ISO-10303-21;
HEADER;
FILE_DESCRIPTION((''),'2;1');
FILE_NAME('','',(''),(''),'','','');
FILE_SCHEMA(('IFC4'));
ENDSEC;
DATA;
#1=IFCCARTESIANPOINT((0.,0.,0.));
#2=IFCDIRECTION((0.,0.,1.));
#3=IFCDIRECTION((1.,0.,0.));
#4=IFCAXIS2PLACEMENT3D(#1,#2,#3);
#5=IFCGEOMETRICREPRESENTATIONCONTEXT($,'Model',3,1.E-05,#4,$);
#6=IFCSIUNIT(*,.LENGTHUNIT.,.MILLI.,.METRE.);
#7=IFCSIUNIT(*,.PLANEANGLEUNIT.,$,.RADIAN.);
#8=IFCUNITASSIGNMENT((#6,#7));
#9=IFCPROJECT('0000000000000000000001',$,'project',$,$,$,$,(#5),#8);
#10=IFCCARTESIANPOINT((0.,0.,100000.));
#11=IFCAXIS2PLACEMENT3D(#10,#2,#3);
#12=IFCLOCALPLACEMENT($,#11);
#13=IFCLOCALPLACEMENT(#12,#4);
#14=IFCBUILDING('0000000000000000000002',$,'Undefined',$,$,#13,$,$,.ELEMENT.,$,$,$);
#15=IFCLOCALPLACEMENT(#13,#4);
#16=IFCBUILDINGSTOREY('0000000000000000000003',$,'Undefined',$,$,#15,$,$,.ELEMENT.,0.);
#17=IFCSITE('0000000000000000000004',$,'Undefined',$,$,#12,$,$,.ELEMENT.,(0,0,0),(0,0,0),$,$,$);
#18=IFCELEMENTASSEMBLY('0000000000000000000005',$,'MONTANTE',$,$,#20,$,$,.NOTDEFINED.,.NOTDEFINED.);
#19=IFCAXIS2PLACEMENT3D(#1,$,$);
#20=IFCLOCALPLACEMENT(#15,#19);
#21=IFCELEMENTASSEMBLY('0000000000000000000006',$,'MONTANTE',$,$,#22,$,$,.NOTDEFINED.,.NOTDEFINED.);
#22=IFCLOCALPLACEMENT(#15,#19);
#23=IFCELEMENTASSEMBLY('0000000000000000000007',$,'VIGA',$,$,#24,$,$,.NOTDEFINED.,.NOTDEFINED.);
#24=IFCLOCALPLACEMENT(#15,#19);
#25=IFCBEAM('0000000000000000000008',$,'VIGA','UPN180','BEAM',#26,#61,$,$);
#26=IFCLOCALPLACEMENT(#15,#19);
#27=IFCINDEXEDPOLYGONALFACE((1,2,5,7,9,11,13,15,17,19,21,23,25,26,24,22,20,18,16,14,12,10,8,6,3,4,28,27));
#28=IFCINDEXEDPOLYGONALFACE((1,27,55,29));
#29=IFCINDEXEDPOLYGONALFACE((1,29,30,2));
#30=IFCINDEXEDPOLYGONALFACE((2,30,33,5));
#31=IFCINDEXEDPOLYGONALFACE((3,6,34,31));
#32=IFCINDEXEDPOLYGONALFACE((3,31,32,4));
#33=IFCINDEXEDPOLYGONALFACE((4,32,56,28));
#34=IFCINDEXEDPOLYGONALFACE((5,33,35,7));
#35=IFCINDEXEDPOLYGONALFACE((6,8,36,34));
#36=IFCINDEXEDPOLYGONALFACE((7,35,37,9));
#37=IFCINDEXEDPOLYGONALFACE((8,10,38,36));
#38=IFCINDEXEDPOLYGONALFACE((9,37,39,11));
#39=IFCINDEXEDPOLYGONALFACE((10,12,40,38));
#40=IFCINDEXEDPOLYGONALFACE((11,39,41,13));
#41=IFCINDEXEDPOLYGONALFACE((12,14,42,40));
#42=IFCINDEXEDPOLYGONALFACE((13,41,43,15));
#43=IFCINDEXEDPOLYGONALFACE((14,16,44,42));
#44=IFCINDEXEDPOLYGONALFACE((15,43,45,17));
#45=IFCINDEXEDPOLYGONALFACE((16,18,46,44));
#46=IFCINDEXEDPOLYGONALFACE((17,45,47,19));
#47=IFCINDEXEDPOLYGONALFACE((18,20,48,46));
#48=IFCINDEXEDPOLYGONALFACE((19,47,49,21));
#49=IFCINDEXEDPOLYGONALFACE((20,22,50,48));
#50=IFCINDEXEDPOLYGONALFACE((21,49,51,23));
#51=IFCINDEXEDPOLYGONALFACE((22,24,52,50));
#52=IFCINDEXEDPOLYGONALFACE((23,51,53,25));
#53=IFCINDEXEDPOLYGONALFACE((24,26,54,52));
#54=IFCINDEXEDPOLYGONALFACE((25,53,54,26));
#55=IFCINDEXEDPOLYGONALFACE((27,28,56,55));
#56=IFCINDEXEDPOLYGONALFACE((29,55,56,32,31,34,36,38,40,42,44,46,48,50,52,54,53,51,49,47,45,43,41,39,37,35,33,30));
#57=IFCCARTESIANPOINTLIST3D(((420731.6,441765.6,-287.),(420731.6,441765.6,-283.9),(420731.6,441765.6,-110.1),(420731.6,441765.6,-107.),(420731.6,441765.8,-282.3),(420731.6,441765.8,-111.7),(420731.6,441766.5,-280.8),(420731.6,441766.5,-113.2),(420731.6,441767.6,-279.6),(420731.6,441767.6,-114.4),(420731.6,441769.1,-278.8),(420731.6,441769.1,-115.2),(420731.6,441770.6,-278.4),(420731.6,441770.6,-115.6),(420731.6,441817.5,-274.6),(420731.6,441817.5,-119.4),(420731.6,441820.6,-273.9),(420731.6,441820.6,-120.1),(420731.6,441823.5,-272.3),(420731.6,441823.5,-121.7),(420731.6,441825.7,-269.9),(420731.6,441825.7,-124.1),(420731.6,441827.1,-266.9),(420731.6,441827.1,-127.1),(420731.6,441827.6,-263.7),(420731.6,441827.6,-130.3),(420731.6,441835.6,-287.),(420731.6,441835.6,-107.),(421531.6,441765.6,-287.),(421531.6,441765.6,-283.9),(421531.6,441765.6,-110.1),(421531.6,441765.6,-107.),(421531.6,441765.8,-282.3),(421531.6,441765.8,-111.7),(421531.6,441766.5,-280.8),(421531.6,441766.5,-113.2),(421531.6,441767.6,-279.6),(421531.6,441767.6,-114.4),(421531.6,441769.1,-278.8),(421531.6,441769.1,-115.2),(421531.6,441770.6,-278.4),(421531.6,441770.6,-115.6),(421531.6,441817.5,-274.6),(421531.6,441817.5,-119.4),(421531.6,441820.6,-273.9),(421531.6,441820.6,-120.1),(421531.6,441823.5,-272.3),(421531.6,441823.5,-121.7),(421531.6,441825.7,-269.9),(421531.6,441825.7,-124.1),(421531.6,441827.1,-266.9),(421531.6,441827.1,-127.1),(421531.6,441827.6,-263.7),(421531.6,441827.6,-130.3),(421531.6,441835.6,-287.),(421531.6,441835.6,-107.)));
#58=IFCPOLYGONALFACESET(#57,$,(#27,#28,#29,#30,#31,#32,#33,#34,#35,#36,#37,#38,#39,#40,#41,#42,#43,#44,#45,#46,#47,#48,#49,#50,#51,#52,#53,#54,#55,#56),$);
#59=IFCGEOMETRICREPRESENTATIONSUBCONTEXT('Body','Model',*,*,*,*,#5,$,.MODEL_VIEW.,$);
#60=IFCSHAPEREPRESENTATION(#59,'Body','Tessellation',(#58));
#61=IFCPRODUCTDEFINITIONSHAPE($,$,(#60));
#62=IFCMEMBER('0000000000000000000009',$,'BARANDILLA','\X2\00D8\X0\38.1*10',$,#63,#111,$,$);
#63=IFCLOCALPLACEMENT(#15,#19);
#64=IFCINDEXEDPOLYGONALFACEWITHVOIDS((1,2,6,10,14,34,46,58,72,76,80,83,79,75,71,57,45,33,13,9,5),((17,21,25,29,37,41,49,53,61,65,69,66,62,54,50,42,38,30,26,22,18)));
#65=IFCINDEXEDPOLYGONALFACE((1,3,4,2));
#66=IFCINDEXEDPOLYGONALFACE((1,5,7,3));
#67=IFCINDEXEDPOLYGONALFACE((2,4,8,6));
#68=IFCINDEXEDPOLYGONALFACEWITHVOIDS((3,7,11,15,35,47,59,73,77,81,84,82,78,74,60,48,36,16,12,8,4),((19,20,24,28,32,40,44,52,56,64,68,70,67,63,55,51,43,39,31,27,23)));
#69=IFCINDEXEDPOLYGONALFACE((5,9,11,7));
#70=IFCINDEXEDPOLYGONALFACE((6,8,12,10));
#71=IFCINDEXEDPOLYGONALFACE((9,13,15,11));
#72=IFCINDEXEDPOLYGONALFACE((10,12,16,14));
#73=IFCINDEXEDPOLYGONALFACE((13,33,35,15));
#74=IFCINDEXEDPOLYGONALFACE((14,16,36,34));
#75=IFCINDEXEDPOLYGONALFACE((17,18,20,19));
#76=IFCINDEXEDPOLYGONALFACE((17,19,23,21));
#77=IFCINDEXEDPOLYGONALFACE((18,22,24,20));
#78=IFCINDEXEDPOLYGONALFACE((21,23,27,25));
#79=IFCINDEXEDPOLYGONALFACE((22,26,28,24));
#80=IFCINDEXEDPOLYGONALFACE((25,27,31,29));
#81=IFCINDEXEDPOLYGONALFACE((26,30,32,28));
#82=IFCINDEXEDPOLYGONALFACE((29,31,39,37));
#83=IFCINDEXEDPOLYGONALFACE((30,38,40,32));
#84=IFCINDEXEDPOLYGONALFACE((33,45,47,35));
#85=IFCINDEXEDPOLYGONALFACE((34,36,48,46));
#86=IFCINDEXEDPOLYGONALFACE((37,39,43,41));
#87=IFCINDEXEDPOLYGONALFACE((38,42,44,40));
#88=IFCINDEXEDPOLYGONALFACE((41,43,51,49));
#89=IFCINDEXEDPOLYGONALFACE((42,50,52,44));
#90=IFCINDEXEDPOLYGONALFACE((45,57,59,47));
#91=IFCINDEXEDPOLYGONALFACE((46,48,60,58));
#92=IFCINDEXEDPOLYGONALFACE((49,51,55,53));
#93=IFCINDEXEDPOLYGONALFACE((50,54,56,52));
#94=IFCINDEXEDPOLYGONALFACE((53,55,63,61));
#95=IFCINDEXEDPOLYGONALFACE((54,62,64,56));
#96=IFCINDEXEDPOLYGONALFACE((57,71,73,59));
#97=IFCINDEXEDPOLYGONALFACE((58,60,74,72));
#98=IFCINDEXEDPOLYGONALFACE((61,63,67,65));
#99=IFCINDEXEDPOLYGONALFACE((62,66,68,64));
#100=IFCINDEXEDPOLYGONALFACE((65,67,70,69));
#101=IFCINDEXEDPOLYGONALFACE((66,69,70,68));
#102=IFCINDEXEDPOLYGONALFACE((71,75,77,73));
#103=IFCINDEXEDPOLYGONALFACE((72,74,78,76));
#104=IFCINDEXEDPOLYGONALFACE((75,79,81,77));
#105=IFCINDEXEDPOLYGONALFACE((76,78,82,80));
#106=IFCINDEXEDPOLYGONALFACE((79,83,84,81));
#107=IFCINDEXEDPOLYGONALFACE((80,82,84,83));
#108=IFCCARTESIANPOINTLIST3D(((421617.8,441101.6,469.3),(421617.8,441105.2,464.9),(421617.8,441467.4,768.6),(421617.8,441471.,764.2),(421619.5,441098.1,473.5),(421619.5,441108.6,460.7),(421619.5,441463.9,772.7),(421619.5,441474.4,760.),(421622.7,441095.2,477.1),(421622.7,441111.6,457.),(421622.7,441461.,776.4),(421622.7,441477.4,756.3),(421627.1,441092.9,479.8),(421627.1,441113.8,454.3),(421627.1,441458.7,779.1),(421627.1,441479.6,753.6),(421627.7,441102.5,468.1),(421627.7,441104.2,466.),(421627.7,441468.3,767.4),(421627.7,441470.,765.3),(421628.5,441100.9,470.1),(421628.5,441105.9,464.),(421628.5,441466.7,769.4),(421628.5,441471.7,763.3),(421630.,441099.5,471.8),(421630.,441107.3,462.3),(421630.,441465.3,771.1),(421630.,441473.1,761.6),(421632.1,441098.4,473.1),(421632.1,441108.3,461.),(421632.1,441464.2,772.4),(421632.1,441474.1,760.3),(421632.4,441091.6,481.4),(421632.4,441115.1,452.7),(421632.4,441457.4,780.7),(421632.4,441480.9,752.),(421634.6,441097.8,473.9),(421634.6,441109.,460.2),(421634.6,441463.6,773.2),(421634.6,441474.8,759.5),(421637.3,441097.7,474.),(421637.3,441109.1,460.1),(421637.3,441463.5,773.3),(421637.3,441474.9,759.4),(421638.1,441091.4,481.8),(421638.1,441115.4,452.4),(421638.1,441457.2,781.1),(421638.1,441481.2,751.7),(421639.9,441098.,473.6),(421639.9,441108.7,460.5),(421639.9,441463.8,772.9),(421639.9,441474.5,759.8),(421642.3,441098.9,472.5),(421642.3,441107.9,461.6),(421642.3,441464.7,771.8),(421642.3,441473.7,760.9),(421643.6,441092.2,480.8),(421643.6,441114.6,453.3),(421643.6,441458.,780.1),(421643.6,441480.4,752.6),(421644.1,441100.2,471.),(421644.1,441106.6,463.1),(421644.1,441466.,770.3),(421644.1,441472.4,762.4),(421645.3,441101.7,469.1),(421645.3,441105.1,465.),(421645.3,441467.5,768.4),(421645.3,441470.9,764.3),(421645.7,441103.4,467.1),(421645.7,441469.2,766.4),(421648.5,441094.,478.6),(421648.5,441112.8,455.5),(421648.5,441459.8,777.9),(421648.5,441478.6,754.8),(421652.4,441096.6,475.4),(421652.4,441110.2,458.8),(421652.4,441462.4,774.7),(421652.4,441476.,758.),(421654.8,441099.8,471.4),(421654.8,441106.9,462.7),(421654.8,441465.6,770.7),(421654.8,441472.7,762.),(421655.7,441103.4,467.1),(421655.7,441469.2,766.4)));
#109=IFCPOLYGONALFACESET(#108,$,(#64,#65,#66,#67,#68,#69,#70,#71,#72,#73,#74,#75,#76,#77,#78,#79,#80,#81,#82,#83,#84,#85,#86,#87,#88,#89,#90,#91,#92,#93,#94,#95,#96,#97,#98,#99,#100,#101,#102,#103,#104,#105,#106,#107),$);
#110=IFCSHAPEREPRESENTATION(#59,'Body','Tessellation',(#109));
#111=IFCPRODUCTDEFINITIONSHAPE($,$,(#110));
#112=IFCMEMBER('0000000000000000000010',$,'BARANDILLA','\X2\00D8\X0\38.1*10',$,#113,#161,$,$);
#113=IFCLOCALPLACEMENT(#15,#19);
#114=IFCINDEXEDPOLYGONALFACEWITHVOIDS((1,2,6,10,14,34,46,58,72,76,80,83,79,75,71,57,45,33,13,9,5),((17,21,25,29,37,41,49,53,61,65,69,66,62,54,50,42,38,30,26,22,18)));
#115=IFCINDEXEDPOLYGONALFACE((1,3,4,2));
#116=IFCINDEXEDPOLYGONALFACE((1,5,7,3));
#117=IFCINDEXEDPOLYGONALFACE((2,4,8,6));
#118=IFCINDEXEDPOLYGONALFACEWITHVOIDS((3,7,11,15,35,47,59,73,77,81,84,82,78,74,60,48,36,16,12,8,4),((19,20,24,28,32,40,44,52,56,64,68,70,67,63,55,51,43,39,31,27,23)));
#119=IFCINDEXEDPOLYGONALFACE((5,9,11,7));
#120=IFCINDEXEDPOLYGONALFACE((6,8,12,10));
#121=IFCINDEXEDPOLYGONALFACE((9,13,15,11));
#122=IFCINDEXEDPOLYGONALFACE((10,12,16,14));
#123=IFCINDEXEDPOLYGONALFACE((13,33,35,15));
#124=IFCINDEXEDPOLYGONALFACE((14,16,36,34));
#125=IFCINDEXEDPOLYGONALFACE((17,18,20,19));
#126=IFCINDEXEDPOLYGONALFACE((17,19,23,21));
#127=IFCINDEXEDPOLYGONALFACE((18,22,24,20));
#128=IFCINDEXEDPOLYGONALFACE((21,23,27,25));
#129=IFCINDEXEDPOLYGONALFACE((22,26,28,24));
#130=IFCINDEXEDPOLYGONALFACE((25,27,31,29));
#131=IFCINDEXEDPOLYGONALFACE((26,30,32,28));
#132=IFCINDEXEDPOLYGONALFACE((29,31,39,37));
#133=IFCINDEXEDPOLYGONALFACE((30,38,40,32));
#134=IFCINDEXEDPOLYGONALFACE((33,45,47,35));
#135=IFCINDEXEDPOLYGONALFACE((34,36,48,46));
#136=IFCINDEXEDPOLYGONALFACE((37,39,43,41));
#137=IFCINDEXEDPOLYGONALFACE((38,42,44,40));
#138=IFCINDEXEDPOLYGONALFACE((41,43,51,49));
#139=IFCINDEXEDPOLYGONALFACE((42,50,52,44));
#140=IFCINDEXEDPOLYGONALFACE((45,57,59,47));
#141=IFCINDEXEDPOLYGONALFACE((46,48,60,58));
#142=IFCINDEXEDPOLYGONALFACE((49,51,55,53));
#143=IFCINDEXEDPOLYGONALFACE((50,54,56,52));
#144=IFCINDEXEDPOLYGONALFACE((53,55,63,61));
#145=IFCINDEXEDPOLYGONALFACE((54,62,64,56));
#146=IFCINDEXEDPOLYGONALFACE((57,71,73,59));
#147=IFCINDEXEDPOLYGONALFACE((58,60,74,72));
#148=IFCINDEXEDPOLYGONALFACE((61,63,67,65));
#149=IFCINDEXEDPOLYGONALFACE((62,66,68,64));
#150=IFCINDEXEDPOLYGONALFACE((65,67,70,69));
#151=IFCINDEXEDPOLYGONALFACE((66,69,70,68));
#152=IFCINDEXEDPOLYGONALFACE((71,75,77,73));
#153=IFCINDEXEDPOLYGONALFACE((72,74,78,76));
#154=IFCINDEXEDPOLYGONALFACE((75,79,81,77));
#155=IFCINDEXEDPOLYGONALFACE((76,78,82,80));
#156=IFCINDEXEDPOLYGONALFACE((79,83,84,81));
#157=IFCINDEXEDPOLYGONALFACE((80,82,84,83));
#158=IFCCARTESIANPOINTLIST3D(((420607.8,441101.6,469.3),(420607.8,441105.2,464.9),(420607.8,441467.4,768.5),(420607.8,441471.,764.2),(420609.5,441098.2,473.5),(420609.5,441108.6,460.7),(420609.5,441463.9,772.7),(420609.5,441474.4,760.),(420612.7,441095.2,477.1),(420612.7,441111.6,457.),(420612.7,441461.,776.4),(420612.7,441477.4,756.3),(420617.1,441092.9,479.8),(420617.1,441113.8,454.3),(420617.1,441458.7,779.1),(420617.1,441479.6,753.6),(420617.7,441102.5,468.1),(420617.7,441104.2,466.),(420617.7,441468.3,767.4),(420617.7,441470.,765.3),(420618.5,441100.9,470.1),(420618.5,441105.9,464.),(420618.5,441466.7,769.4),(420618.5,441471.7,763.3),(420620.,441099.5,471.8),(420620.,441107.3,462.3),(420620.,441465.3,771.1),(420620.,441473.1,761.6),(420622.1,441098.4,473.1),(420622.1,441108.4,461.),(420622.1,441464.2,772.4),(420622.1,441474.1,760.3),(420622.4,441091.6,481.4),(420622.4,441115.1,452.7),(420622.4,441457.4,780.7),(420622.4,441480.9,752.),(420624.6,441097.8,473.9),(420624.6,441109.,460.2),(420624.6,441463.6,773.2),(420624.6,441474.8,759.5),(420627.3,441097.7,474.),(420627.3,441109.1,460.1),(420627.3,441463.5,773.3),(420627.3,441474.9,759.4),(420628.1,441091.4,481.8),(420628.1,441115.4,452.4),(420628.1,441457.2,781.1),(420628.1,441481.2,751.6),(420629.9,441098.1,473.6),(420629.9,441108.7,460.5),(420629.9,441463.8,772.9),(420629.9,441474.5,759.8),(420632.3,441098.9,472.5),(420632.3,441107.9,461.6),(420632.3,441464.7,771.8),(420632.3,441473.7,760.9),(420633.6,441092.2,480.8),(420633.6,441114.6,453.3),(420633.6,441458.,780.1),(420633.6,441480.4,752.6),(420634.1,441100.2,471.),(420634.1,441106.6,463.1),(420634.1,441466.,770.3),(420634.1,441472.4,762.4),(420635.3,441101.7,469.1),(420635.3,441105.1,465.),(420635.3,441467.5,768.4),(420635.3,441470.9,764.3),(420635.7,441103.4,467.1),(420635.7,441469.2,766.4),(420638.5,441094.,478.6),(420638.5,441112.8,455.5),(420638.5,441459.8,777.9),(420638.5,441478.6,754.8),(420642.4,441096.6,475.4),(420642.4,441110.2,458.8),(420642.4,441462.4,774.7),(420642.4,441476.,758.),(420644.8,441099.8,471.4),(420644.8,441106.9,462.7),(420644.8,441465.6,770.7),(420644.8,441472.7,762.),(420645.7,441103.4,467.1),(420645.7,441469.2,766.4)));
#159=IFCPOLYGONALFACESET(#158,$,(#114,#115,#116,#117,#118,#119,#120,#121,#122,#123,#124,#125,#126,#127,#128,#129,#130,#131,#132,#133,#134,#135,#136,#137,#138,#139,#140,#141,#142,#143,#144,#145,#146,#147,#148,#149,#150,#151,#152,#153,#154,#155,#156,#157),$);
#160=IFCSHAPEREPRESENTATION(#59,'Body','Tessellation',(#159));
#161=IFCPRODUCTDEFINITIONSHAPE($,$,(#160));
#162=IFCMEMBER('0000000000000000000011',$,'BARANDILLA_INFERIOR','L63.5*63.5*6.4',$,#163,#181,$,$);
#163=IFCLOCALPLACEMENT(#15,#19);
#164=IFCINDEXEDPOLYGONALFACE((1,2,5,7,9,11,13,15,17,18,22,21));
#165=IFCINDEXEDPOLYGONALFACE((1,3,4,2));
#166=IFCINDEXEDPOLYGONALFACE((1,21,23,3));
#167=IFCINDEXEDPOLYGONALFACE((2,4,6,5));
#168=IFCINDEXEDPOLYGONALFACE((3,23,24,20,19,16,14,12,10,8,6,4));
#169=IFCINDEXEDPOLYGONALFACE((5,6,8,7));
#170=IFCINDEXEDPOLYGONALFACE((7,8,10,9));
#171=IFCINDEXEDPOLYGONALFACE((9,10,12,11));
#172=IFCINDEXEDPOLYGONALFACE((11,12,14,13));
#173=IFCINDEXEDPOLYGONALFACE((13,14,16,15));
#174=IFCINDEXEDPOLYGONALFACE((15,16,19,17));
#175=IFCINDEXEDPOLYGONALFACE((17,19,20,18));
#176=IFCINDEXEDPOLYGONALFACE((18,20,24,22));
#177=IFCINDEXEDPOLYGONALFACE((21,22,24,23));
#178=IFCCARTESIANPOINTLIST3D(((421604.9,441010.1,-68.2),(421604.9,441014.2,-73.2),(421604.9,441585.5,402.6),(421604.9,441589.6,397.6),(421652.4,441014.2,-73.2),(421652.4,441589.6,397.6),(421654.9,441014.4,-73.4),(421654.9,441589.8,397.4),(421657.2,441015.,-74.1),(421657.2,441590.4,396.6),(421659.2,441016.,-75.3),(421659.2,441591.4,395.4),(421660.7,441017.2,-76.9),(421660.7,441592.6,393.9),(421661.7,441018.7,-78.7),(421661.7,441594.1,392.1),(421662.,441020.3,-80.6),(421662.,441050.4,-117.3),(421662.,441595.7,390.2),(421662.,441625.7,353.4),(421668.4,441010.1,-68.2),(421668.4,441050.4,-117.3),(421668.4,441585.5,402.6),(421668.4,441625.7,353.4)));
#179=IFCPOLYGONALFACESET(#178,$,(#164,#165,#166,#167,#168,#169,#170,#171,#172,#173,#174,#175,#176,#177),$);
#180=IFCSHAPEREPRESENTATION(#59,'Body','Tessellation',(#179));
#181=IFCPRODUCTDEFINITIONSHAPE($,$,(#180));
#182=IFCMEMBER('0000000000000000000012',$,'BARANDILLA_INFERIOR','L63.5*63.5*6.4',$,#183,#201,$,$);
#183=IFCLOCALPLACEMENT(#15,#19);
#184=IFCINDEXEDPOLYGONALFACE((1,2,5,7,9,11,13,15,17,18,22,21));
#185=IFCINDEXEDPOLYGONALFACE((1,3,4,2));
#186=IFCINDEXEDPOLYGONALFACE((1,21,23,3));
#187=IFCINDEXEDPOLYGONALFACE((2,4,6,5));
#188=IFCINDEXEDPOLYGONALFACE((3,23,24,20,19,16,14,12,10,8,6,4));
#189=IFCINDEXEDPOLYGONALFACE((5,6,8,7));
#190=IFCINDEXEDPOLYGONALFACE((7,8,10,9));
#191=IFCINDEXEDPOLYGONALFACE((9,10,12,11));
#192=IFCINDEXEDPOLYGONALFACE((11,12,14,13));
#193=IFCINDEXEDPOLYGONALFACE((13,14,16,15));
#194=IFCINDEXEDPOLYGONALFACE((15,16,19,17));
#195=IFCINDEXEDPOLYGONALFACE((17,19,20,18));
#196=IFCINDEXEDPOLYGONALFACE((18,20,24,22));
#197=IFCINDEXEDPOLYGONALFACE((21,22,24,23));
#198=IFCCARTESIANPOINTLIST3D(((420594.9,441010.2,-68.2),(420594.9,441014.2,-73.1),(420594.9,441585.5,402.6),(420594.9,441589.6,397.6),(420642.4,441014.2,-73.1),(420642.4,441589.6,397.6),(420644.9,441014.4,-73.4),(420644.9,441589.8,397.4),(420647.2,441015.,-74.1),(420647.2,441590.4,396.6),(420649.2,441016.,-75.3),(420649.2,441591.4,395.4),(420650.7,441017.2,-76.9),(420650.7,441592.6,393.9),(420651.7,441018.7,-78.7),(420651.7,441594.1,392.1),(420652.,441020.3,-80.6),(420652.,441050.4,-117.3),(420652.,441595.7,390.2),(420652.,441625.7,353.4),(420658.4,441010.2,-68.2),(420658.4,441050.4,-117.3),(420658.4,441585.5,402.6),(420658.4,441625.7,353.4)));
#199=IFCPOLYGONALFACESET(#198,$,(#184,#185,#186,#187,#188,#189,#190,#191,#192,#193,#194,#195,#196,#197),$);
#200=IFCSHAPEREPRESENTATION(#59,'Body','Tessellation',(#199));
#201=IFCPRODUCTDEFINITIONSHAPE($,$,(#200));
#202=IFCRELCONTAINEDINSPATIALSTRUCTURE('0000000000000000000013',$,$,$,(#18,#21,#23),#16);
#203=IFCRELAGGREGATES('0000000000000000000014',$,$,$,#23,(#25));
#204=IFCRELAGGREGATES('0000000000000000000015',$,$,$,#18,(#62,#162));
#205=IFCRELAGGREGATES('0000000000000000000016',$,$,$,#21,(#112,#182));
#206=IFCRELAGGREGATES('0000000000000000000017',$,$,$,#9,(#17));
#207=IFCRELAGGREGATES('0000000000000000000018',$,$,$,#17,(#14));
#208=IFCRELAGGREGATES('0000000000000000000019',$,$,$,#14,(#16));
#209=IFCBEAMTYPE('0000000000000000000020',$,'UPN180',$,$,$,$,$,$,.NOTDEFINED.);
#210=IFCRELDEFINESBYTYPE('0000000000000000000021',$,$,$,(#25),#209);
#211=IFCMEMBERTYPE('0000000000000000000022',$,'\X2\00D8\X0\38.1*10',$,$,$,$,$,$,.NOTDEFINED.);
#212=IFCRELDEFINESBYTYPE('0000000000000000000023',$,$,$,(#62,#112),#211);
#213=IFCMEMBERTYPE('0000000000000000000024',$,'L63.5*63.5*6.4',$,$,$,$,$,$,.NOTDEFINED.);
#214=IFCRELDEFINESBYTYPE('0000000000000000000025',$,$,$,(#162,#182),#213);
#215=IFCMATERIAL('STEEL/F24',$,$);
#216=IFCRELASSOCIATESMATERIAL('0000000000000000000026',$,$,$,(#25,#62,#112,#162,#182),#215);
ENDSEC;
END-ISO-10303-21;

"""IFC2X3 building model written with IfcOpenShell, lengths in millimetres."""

from ifc_helpers import new_model, si_unit, frame, origin_with_axes, origin_2d_with_axis, place, context, subcontext, project, spatial, hollow_circle, l_section, u_section, extrude, clip, halfspace, material, type_object, element, aggregate, save


model = new_model("IFC2X3")

# Units and contexts
model_context = context("Model", 3, precision=1e-05, world=origin_with_axes())
body_context = subcontext(model_context, "Body", "Model", "MODEL_VIEW")
ifc_project = project(units=[si_unit("LENGTHUNIT", "METRE", prefix="MILLI"), si_unit("PLANEANGLEUNIT", "RADIAN")], contexts=[model_context])

# Site, building, storey
site_placement = place(None, frame((0.0, 0.0, 100000.0), z_axis=(0.0, 0.0, 1.0), x_axis=(1.0, 0.0, 0.0)))
site = spatial("IfcSite", under=ifc_project, at=site_placement, Name="Undefined", CompositionType="ELEMENT", RefLatitude=(0, 0, 0), RefLongitude=(0, 0, 0))
building_placement = place(site_placement, origin_with_axes())
building = spatial("IfcBuilding", under=site, at=building_placement, Name="Undefined", CompositionType="ELEMENT")
storey_placement = place(building_placement, origin_with_axes())
storey = spatial("IfcBuildingStorey", under=building, at=storey_placement, Name="Undefined", CompositionType="ELEMENT", Elevation=0.0)

# Element assemblies
assembly_1_placement = place(storey_placement, origin_with_axes())
assembly_1 = element("IfcElementAssembly", 1, at=assembly_1_placement, inside=storey, Name="MONTANTE", AssemblyPlace="NOTDEFINED", PredefinedType="NOTDEFINED")
ifc_material_1 = material(Name="STEEL/F24")
assembly_2_placement = place(storey_placement, origin_with_axes())
assembly_2 = element("IfcElementAssembly", 2, at=assembly_2_placement, inside=storey, Name="MONTANTE", AssemblyPlace="NOTDEFINED", PredefinedType="NOTDEFINED")

# Element assembly, beam
beam_type_1 = type_object("IfcBeamType", Name="UPN180", PredefinedType="NOTDEFINED")
assembly_3_placement = place(storey_placement, origin_with_axes())
assembly_3 = element("IfcElementAssembly", 3, at=assembly_3_placement, inside=storey, Name="VIGA", AssemblyPlace="NOTDEFINED", PredefinedType="NOTDEFINED")
beam_1_placement = place(assembly_3_placement, frame((421531.6, 441800.6, -197.0), z_axis=(0.0, 0.0, -1.0), x_axis=(-1.0, 0.0, 0.0)))
beam_1 = element("IfcBeam", 4, at=beam_1_placement, type_object=beam_type_1, material=ifc_material_1, Name="VIGA", Description="UPN180", ObjectType="BEAM", context=body_context, shape_type="SweptSolid", body=[
    extrude(u_section(Depth=180.0, FlangeWidth=70.0, WebThickness=8.0, FlangeThickness=11.0, FilletRadius=11.0, EdgeRadius=5.5, FlangeSlope=0.07983, at=origin_2d_with_axis()), frame((800.0, 0.0, 0.0), z_axis=(-1.0, 0.0, 0.0), x_axis=(0.0, -1.0, 0.0)), (0.0, 0.0, 1.0), 800.0),
])
aggregate(assembly_3, [beam_1])

# Members
member_type_1 = type_object("IfcMemberType", Name="Ø38.1*10", PredefinedType="NOTDEFINED")
member_1_placement = place(assembly_1_placement, frame((421636.6, 441469.2, 766.4), z_axis=(0.000001, 0.633238, -0.773957), x_axis=(-0.000001, -0.773957, -0.633238)))
member_1 = element("IfcMember", 5, at=member_1_placement, type_object=member_type_1, material=ifc_material_1, Name="BARANDILLA", Description="Ø38.1*10", context=body_context, shape_type="Clipping", body=[
    clip(clip(extrude(hollow_circle(Radius=19.1, WallThickness=10.0, at=origin_2d_with_axis()), frame((510.4, 0.0, 0.0), z_axis=(-1.0, 0.0, 0.0), x_axis=(0.0, -1.0, 0.0)), (0.0, 0.0, 1.0), 548.1), halfspace(frame((472.6, 0.0, 0.0), z_axis=(1.0, 0.0, 0.0), x_axis=(0.0, -1.0, 0.0)), False)), halfspace(frame((0.0, 0.0, 0.0), z_axis=(1.0, 0.0, 0.0), x_axis=(0.0, -1.0, 0.0)), True)),
])
member_2_placement = place(assembly_2_placement, frame((420626.6, 441469.2, 766.4), z_axis=(0.000001, 0.633238, -0.773957), x_axis=(-0.000001, -0.773957, -0.633238)))
member_2 = element("IfcMember", 6, at=member_2_placement, type_object=member_type_1, material=ifc_material_1, Name="BARANDILLA", Description="Ø38.1*10", context=body_context, shape_type="Clipping", body=[
    clip(clip(extrude(hollow_circle(Radius=19.1, WallThickness=10.0, at=origin_2d_with_axis()), frame((510.3, 0.0, 0.0), z_axis=(-1.0, 0.0, 0.0), x_axis=(0.0, -1.0, 0.0)), (0.0, 0.0, 1.0), 548.1), halfspace(frame((472.6, 0.0, 0.0), z_axis=(1.0, 0.0, 0.0), x_axis=(0.0, -1.0, 0.0)), False)), halfspace(frame((0.0, 0.0, 0.0), z_axis=(1.0, 0.0, 0.0), x_axis=(0.0, -1.0, 0.0)), True)),
])
member_type_2 = type_object("IfcMemberType", Name="L63.5*63.5*6.4", PredefinedType="NOTDEFINED")
member_3_placement = place(assembly_1_placement, frame((421636.6, 441605.6, 378.0), z_axis=(-1.0, 0.000001, 0.0), x_axis=(-0.000001, -0.773957, -0.633238)))
member_3 = element("IfcMember", 7, at=member_3_placement, type_object=member_type_2, material=ifc_material_1, Name="BARANDILLA_INFERIOR", Description="L63.5*63.5*6.4", context=body_context, shape_type="SweptSolid", body=[
    extrude(l_section(Depth=63.5, Width=63.5, Thickness=6.4, FilletRadius=9.6, at=origin_2d_with_axis()), frame((743.4, 0.0, 0.0), z_axis=(-1.0, 0.0, 0.0), x_axis=(0.0, -1.0, 0.0)), (0.0, 0.0, 1.0), 743.4),
])
member_4_placement = place(assembly_2_placement, frame((420626.6, 441605.6, 378.0), z_axis=(-1.0, 0.000001, 0.0), x_axis=(-0.000001, -0.773957, -0.633238)))
member_4 = element("IfcMember", 8, at=member_4_placement, type_object=member_type_2, material=ifc_material_1, Name="BARANDILLA_INFERIOR", Description="L63.5*63.5*6.4", context=body_context, shape_type="SweptSolid", body=[
    extrude(l_section(Depth=63.5, Width=63.5, Thickness=6.4, FilletRadius=9.6, at=origin_2d_with_axis()), frame((743.4, 0.0, 0.0), z_axis=(-1.0, 0.0, 0.0), x_axis=(0.0, -1.0, 0.0)), (0.0, 0.0, 1.0), 743.4),
])

aggregate(assembly_1, [member_1, member_3])
aggregate(assembly_2, [member_2, member_4])

save(model, "model.ifc")
